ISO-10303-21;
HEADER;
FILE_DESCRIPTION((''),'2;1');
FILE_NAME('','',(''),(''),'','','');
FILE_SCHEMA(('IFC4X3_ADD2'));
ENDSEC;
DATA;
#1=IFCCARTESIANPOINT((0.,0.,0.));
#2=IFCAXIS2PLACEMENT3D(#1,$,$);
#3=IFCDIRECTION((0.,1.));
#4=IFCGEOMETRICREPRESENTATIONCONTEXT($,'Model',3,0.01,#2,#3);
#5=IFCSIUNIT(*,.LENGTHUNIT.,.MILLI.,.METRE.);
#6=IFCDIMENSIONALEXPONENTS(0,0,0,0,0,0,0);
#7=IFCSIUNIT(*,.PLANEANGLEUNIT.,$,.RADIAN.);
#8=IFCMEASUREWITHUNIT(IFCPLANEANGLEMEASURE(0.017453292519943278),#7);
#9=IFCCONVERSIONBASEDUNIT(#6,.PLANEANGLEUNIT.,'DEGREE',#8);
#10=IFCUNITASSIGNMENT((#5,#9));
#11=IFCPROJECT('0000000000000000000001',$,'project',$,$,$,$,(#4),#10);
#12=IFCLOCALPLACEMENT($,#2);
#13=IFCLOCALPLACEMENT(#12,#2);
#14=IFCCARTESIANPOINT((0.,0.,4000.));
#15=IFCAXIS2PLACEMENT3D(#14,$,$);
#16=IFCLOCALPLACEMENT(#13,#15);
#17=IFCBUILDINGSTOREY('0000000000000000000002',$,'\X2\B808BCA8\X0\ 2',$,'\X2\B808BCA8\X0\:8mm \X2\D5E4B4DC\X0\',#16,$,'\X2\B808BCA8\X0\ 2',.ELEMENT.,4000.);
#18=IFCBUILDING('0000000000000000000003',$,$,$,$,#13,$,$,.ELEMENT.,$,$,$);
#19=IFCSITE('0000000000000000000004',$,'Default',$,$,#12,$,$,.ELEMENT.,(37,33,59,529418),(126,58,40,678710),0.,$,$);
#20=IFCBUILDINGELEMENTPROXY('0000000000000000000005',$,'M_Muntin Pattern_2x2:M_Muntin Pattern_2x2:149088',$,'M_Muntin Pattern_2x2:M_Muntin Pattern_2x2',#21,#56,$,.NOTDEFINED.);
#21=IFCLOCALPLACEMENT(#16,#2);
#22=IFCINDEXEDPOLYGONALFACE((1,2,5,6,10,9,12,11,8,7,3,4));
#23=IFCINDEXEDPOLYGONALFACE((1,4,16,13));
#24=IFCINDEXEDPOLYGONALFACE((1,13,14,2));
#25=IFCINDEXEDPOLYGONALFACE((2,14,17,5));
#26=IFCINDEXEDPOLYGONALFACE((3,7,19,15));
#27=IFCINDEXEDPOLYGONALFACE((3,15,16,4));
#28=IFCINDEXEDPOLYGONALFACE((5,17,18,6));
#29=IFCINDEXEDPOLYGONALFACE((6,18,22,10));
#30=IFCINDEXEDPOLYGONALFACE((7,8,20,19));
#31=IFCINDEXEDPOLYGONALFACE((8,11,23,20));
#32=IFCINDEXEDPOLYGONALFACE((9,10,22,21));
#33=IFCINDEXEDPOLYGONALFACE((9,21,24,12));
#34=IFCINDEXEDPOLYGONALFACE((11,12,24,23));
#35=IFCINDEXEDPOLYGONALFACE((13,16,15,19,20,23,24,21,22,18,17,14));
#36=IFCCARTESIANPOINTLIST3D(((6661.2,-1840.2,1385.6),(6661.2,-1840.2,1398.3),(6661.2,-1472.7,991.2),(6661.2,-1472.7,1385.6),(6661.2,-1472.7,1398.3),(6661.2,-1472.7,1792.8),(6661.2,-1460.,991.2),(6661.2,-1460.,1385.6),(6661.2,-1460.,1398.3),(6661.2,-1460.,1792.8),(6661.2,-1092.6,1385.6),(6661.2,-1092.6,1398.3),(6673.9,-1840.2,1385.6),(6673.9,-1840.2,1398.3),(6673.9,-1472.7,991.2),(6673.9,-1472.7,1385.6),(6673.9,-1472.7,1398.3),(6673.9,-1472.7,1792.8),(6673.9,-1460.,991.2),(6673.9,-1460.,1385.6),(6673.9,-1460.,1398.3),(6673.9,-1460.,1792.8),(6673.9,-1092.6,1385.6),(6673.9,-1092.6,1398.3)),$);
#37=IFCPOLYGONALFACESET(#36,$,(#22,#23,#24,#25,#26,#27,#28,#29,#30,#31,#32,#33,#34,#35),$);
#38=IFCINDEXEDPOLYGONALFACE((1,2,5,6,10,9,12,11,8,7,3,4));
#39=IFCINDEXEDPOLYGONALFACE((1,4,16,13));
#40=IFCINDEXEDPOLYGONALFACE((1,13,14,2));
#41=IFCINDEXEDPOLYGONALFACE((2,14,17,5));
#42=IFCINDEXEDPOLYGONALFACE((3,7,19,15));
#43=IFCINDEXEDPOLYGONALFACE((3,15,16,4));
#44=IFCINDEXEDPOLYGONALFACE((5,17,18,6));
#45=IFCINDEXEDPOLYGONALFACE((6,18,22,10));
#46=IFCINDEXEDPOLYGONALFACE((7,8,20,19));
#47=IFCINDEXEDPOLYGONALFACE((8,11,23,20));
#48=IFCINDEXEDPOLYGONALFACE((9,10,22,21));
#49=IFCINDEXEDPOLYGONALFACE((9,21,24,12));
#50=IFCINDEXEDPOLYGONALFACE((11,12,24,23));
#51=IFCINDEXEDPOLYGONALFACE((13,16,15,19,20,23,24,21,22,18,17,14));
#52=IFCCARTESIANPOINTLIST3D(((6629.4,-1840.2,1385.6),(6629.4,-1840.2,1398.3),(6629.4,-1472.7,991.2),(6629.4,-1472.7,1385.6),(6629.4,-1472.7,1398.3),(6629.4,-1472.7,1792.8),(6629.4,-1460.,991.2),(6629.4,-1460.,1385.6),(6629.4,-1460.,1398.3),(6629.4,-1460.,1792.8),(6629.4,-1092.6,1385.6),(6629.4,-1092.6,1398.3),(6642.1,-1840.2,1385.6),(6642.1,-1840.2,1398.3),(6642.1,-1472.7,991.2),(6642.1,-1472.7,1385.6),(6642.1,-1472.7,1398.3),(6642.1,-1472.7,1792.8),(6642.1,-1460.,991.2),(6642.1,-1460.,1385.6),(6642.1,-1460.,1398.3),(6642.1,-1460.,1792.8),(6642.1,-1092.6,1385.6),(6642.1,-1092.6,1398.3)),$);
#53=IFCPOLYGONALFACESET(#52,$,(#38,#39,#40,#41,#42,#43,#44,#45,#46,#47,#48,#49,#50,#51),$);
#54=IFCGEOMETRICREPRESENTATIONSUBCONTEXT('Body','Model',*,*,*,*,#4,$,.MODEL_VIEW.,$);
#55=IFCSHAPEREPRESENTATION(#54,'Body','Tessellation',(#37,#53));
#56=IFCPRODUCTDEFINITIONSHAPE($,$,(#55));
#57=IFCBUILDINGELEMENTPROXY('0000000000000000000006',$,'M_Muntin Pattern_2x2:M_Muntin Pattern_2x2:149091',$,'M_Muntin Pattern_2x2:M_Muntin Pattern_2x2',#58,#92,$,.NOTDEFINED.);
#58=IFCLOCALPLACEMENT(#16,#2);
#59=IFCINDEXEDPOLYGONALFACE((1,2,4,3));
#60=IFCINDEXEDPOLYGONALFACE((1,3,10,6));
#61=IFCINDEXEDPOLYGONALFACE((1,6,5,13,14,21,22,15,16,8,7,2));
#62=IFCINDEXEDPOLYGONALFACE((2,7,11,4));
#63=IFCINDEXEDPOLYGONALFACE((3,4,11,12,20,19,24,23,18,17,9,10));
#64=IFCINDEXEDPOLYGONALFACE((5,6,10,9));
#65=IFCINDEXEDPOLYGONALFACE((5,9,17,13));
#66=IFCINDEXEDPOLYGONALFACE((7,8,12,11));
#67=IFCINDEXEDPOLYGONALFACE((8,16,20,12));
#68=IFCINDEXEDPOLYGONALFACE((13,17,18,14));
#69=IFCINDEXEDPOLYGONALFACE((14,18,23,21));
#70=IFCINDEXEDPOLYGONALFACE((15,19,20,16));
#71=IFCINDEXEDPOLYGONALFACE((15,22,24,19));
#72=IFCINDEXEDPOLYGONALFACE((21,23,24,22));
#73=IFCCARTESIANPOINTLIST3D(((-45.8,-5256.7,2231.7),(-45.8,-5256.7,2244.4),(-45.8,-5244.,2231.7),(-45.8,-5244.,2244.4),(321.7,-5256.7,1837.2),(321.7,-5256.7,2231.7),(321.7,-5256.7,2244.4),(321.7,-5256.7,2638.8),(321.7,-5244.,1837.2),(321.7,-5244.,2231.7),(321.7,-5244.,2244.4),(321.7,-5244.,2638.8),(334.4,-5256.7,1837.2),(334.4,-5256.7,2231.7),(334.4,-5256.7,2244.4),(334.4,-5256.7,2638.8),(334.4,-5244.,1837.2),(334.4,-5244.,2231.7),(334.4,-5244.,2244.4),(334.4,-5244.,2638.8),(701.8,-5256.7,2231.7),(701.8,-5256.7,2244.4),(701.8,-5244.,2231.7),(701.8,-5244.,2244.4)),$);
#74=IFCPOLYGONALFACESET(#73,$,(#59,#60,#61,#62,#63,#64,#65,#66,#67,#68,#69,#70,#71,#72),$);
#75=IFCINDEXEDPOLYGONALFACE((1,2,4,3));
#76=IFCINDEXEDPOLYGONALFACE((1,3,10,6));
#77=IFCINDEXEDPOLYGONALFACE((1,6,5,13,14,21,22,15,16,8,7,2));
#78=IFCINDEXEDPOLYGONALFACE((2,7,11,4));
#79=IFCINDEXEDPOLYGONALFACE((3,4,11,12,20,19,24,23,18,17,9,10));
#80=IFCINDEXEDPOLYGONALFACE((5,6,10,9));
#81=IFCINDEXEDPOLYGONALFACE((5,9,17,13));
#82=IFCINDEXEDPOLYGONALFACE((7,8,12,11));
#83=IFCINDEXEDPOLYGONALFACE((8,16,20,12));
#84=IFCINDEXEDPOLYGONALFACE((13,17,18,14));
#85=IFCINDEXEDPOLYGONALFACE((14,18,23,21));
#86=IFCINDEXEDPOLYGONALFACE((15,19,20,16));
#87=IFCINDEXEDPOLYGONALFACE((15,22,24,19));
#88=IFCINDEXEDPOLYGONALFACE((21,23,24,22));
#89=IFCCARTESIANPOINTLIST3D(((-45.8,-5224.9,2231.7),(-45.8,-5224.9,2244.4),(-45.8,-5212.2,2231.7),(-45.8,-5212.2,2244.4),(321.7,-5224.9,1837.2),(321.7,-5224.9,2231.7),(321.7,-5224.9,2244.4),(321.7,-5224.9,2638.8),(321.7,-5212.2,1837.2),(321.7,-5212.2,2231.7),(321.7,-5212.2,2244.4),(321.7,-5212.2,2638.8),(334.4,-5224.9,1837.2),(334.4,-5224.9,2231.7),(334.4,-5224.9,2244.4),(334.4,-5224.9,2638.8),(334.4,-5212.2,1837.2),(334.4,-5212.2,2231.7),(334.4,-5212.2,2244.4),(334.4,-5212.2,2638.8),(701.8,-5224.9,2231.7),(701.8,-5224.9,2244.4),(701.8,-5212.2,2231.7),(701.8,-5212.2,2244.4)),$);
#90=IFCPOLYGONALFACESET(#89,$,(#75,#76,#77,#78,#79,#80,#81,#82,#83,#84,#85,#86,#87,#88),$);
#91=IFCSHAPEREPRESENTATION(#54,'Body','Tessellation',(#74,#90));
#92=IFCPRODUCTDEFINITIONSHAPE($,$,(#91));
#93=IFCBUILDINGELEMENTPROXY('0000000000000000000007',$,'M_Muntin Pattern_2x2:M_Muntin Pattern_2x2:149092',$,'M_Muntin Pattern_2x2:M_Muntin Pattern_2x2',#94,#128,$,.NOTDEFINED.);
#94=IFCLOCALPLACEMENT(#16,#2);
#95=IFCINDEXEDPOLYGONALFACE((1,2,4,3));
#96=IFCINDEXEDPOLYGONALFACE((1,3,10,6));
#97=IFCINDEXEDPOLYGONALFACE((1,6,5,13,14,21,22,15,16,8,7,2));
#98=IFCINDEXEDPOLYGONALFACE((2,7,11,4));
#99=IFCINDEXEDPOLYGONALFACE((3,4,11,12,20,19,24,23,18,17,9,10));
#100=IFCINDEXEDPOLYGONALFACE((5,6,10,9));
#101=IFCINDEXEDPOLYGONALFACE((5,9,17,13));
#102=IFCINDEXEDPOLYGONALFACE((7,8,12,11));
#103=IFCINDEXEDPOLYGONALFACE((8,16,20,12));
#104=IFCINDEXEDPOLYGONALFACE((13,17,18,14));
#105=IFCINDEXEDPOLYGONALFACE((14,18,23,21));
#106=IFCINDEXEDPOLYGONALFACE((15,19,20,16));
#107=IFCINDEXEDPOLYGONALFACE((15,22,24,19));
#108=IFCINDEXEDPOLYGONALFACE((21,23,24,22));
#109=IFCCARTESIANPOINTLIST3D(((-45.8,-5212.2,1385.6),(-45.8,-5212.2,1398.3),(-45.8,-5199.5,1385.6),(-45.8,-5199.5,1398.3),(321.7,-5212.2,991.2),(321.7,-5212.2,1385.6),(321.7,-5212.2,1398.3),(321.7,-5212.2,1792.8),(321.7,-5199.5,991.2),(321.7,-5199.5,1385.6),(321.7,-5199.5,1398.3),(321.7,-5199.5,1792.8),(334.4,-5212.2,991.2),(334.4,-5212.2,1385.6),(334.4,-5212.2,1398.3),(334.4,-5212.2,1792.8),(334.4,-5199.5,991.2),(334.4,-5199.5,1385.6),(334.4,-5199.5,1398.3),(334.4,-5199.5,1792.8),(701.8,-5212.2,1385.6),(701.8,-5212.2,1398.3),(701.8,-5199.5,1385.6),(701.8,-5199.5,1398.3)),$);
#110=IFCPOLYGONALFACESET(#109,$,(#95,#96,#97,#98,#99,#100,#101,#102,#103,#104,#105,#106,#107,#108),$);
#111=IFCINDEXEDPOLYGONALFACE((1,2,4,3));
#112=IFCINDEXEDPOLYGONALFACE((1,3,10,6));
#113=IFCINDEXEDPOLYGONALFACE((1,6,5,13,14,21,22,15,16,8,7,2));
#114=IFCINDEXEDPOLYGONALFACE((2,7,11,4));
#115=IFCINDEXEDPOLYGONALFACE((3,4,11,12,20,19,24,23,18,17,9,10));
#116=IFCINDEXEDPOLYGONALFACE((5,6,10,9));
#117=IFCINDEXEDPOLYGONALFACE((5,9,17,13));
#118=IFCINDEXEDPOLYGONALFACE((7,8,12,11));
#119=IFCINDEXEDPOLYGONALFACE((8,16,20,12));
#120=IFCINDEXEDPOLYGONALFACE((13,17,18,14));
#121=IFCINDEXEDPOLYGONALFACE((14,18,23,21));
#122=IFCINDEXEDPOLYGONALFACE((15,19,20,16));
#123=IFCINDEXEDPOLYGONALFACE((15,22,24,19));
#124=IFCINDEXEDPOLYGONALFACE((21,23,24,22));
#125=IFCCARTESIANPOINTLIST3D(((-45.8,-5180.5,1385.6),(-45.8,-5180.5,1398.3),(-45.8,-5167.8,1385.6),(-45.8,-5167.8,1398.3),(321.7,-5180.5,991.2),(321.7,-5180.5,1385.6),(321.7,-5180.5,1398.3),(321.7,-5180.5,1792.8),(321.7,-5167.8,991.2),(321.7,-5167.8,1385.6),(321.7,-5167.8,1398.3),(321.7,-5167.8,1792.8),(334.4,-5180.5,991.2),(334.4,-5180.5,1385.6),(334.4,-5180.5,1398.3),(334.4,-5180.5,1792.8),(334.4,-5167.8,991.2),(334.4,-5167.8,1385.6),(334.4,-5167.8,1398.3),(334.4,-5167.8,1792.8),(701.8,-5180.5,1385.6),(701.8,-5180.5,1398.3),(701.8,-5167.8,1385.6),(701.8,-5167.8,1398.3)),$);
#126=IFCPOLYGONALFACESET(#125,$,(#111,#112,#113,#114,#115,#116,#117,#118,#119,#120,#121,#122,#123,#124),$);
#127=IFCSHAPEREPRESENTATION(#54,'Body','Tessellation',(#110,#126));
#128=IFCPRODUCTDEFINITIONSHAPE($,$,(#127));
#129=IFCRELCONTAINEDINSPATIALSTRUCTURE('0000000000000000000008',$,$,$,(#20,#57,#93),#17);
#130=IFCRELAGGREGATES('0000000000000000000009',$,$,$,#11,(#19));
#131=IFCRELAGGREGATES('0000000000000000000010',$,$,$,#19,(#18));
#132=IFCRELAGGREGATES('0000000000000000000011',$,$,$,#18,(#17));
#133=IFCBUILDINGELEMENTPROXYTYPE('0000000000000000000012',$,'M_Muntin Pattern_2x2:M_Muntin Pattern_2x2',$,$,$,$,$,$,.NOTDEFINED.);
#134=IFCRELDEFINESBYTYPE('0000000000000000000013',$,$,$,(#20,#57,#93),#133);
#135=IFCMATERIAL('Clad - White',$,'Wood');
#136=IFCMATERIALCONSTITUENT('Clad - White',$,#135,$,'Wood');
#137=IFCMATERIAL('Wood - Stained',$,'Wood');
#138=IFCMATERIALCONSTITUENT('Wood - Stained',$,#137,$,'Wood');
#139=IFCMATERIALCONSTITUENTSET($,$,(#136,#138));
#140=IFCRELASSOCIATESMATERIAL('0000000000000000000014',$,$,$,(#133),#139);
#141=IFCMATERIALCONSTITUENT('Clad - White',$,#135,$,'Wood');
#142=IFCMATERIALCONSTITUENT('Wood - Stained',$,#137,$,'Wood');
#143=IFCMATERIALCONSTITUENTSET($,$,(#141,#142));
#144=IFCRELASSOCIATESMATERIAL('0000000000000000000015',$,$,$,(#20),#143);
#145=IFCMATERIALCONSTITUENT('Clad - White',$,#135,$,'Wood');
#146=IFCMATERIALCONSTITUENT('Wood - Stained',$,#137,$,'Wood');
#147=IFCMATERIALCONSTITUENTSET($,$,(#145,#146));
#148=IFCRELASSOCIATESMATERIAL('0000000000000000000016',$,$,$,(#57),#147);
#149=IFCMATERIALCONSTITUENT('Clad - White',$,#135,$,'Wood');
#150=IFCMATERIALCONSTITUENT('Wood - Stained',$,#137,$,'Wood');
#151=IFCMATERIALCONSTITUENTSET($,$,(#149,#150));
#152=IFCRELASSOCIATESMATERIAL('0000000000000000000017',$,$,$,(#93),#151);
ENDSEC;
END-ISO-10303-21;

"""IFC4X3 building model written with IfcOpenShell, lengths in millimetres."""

from ifc_helpers import new_model, entity, si_unit, converted_unit, direction, frame, origin, place, context, subcontext, project, spatial, polyline, outline, extrude, source, transform, mapped, material, constituent, constituent_set, type_object, type_shapes, element, save


model = new_model("IFC4X3")

# Units and contexts
model_context = context("Model", 3, precision=0.01, world=origin(), true_north=direction((0.0, 1.0)))
body_context = subcontext(model_context, "Body", "Model", "MODEL_VIEW")
ifc_project = project(units=[si_unit("LENGTHUNIT", "METRE", prefix="MILLI"), converted_unit("PLANEANGLEUNIT", "DEGREE", entity("IfcPlaneAngleMeasure", 0.017453292519943278), si_unit("PLANEANGLEUNIT", "RADIAN"), dimensions=[0, 0, 0, 0, 0, 0, 0])], contexts=[model_context])

# Site, building, storey
site_placement = place(None, origin())
site = spatial("IfcSite", under=ifc_project, at=site_placement, Name="Default", CompositionType="ELEMENT", RefLatitude=(37, 33, 59, 529418), RefLongitude=(126, 58, 40, 678710), RefElevation=0.0)
building_placement = place(site_placement, origin())
building = spatial("IfcBuilding", under=site, at=building_placement, CompositionType="ELEMENT")
storey_placement = place(building_placement, frame((0.0, 0.0, 4000.0)))
storey = spatial("IfcBuildingStorey", under=building, at=storey_placement, Name="레벨 2", ObjectType="레벨:8mm 헤드", LongName="레벨 2", CompositionType="ELEMENT", Elevation=4000.0)

# Building element proxies
ifc_material_1 = material(Name="Clad - White", Category="Wood")
ifc_material_2 = material(Name="Wood - Stained", Category="Wood")
ifc_constituent_1 = constituent(ifc_material_1, Name="Clad - White", Category="Wood")
ifc_constituent_2 = constituent(ifc_material_2, Name="Wood - Stained", Category="Wood")
ifc_constituent_set_1 = constituent_set(constituents=[ifc_constituent_1, ifc_constituent_2])
building_element_proxy_type_1 = type_object("IfcBuildingElementProxyType", Name="M_Muntin Pattern_2x2:M_Muntin Pattern_2x2", PredefinedType="NOTDEFINED", material=ifc_constituent_set_1)
shared_shape_1 = source(origin(), body_context, "Body", "SweptSolid", [
    extrude(outline(polyline([(6.4, -6.4), (400.8, -6.4), (400.8, 6.3), (6.4, 6.3), (6.4, 373.8), (-6.3, 373.8), (-6.3, 6.3), (-400.8, 6.3), (-400.8, -6.4), (-6.3, -6.4), (-6.3, -373.8), (6.4, -373.8), (6.4, -6.4)])), frame((0.0, 9.5, 400.8), z_axis=(0.0, 1.0, 0.0), x_axis=(0.0, 0.0, 1.0)), (0.0, 0.0, 1.0), 12.7),
    extrude(outline(polyline([(6.4, -6.4), (400.8, -6.4), (400.8, 6.3), (6.4, 6.3), (6.4, 373.8), (-6.3, 373.8), (-6.3, 6.3), (-400.8, 6.3), (-400.8, -6.4), (-6.3, -6.4), (-6.3, -373.8), (6.4, -373.8), (6.4, -6.4)])), frame((0.0, -22.2, 400.8), z_axis=(0.0, 1.0, 0.0), x_axis=(0.0, 0.0, 1.0)), (0.0, 0.0, 1.0), 12.7),
])
type_shapes(building_element_proxy_type_1, [shared_shape_1])
ifc_constituent_3 = constituent(ifc_material_1, Name="Clad - White", Category="Wood")
ifc_constituent_4 = constituent(ifc_material_2, Name="Wood - Stained", Category="Wood")
ifc_constituent_set_2 = constituent_set(constituents=[ifc_constituent_3, ifc_constituent_4])
proxy_1_placement = place(storey_placement, frame((6651.7, -1466.4, 991.2), z_axis=(0.0, 0.0, 1.0), x_axis=(0.0, -1.0, 0.0)))
element("IfcBuildingElementProxy", 1, at=proxy_1_placement, inside=storey, type_object=building_element_proxy_type_1, material=ifc_constituent_set_2, Name="M_Muntin Pattern_2x2:M_Muntin Pattern_2x2:149088", ObjectType="M_Muntin Pattern_2x2:M_Muntin Pattern_2x2", PredefinedType="NOTDEFINED", context=body_context, shape_type="MappedRepresentation", body=[
    mapped(shared_shape_1, transform((0.0, 0.0, 0.0), scale=1.0)),
])
ifc_constituent_5 = constituent(ifc_material_1, Name="Clad - White", Category="Wood")
ifc_constituent_6 = constituent(ifc_material_2, Name="Wood - Stained", Category="Wood")
ifc_constituent_set_3 = constituent_set(constituents=[ifc_constituent_5, ifc_constituent_6])
proxy_2_placement = place(storey_placement, frame((328.0, -5234.4, 1837.2), z_axis=(0.0, 0.0, 1.0), x_axis=(-1.0, 0.0, 0.0)))
element("IfcBuildingElementProxy", 2, at=proxy_2_placement, inside=storey, type_object=building_element_proxy_type_1, material=ifc_constituent_set_3, Name="M_Muntin Pattern_2x2:M_Muntin Pattern_2x2:149091", ObjectType="M_Muntin Pattern_2x2:M_Muntin Pattern_2x2", PredefinedType="NOTDEFINED", context=body_context, shape_type="MappedRepresentation", body=[
    mapped(shared_shape_1, transform((0.0, 0.0, 0.0), scale=1.0)),
])
ifc_constituent_7 = constituent(ifc_material_1, Name="Clad - White", Category="Wood")
ifc_constituent_8 = constituent(ifc_material_2, Name="Wood - Stained", Category="Wood")
ifc_constituent_set_4 = constituent_set(constituents=[ifc_constituent_7, ifc_constituent_8])
proxy_3_placement = place(storey_placement, frame((328.0, -5190.0, 991.2), z_axis=(0.0, 0.0, 1.0), x_axis=(-1.0, 0.0, 0.0)))
element("IfcBuildingElementProxy", 3, at=proxy_3_placement, inside=storey, type_object=building_element_proxy_type_1, material=ifc_constituent_set_4, Name="M_Muntin Pattern_2x2:M_Muntin Pattern_2x2:149092", ObjectType="M_Muntin Pattern_2x2:M_Muntin Pattern_2x2", PredefinedType="NOTDEFINED", context=body_context, shape_type="MappedRepresentation", body=[
    mapped(shared_shape_1, transform((0.0, 0.0, 0.0), scale=1.0)),
])

save(model, "model.ifc")
